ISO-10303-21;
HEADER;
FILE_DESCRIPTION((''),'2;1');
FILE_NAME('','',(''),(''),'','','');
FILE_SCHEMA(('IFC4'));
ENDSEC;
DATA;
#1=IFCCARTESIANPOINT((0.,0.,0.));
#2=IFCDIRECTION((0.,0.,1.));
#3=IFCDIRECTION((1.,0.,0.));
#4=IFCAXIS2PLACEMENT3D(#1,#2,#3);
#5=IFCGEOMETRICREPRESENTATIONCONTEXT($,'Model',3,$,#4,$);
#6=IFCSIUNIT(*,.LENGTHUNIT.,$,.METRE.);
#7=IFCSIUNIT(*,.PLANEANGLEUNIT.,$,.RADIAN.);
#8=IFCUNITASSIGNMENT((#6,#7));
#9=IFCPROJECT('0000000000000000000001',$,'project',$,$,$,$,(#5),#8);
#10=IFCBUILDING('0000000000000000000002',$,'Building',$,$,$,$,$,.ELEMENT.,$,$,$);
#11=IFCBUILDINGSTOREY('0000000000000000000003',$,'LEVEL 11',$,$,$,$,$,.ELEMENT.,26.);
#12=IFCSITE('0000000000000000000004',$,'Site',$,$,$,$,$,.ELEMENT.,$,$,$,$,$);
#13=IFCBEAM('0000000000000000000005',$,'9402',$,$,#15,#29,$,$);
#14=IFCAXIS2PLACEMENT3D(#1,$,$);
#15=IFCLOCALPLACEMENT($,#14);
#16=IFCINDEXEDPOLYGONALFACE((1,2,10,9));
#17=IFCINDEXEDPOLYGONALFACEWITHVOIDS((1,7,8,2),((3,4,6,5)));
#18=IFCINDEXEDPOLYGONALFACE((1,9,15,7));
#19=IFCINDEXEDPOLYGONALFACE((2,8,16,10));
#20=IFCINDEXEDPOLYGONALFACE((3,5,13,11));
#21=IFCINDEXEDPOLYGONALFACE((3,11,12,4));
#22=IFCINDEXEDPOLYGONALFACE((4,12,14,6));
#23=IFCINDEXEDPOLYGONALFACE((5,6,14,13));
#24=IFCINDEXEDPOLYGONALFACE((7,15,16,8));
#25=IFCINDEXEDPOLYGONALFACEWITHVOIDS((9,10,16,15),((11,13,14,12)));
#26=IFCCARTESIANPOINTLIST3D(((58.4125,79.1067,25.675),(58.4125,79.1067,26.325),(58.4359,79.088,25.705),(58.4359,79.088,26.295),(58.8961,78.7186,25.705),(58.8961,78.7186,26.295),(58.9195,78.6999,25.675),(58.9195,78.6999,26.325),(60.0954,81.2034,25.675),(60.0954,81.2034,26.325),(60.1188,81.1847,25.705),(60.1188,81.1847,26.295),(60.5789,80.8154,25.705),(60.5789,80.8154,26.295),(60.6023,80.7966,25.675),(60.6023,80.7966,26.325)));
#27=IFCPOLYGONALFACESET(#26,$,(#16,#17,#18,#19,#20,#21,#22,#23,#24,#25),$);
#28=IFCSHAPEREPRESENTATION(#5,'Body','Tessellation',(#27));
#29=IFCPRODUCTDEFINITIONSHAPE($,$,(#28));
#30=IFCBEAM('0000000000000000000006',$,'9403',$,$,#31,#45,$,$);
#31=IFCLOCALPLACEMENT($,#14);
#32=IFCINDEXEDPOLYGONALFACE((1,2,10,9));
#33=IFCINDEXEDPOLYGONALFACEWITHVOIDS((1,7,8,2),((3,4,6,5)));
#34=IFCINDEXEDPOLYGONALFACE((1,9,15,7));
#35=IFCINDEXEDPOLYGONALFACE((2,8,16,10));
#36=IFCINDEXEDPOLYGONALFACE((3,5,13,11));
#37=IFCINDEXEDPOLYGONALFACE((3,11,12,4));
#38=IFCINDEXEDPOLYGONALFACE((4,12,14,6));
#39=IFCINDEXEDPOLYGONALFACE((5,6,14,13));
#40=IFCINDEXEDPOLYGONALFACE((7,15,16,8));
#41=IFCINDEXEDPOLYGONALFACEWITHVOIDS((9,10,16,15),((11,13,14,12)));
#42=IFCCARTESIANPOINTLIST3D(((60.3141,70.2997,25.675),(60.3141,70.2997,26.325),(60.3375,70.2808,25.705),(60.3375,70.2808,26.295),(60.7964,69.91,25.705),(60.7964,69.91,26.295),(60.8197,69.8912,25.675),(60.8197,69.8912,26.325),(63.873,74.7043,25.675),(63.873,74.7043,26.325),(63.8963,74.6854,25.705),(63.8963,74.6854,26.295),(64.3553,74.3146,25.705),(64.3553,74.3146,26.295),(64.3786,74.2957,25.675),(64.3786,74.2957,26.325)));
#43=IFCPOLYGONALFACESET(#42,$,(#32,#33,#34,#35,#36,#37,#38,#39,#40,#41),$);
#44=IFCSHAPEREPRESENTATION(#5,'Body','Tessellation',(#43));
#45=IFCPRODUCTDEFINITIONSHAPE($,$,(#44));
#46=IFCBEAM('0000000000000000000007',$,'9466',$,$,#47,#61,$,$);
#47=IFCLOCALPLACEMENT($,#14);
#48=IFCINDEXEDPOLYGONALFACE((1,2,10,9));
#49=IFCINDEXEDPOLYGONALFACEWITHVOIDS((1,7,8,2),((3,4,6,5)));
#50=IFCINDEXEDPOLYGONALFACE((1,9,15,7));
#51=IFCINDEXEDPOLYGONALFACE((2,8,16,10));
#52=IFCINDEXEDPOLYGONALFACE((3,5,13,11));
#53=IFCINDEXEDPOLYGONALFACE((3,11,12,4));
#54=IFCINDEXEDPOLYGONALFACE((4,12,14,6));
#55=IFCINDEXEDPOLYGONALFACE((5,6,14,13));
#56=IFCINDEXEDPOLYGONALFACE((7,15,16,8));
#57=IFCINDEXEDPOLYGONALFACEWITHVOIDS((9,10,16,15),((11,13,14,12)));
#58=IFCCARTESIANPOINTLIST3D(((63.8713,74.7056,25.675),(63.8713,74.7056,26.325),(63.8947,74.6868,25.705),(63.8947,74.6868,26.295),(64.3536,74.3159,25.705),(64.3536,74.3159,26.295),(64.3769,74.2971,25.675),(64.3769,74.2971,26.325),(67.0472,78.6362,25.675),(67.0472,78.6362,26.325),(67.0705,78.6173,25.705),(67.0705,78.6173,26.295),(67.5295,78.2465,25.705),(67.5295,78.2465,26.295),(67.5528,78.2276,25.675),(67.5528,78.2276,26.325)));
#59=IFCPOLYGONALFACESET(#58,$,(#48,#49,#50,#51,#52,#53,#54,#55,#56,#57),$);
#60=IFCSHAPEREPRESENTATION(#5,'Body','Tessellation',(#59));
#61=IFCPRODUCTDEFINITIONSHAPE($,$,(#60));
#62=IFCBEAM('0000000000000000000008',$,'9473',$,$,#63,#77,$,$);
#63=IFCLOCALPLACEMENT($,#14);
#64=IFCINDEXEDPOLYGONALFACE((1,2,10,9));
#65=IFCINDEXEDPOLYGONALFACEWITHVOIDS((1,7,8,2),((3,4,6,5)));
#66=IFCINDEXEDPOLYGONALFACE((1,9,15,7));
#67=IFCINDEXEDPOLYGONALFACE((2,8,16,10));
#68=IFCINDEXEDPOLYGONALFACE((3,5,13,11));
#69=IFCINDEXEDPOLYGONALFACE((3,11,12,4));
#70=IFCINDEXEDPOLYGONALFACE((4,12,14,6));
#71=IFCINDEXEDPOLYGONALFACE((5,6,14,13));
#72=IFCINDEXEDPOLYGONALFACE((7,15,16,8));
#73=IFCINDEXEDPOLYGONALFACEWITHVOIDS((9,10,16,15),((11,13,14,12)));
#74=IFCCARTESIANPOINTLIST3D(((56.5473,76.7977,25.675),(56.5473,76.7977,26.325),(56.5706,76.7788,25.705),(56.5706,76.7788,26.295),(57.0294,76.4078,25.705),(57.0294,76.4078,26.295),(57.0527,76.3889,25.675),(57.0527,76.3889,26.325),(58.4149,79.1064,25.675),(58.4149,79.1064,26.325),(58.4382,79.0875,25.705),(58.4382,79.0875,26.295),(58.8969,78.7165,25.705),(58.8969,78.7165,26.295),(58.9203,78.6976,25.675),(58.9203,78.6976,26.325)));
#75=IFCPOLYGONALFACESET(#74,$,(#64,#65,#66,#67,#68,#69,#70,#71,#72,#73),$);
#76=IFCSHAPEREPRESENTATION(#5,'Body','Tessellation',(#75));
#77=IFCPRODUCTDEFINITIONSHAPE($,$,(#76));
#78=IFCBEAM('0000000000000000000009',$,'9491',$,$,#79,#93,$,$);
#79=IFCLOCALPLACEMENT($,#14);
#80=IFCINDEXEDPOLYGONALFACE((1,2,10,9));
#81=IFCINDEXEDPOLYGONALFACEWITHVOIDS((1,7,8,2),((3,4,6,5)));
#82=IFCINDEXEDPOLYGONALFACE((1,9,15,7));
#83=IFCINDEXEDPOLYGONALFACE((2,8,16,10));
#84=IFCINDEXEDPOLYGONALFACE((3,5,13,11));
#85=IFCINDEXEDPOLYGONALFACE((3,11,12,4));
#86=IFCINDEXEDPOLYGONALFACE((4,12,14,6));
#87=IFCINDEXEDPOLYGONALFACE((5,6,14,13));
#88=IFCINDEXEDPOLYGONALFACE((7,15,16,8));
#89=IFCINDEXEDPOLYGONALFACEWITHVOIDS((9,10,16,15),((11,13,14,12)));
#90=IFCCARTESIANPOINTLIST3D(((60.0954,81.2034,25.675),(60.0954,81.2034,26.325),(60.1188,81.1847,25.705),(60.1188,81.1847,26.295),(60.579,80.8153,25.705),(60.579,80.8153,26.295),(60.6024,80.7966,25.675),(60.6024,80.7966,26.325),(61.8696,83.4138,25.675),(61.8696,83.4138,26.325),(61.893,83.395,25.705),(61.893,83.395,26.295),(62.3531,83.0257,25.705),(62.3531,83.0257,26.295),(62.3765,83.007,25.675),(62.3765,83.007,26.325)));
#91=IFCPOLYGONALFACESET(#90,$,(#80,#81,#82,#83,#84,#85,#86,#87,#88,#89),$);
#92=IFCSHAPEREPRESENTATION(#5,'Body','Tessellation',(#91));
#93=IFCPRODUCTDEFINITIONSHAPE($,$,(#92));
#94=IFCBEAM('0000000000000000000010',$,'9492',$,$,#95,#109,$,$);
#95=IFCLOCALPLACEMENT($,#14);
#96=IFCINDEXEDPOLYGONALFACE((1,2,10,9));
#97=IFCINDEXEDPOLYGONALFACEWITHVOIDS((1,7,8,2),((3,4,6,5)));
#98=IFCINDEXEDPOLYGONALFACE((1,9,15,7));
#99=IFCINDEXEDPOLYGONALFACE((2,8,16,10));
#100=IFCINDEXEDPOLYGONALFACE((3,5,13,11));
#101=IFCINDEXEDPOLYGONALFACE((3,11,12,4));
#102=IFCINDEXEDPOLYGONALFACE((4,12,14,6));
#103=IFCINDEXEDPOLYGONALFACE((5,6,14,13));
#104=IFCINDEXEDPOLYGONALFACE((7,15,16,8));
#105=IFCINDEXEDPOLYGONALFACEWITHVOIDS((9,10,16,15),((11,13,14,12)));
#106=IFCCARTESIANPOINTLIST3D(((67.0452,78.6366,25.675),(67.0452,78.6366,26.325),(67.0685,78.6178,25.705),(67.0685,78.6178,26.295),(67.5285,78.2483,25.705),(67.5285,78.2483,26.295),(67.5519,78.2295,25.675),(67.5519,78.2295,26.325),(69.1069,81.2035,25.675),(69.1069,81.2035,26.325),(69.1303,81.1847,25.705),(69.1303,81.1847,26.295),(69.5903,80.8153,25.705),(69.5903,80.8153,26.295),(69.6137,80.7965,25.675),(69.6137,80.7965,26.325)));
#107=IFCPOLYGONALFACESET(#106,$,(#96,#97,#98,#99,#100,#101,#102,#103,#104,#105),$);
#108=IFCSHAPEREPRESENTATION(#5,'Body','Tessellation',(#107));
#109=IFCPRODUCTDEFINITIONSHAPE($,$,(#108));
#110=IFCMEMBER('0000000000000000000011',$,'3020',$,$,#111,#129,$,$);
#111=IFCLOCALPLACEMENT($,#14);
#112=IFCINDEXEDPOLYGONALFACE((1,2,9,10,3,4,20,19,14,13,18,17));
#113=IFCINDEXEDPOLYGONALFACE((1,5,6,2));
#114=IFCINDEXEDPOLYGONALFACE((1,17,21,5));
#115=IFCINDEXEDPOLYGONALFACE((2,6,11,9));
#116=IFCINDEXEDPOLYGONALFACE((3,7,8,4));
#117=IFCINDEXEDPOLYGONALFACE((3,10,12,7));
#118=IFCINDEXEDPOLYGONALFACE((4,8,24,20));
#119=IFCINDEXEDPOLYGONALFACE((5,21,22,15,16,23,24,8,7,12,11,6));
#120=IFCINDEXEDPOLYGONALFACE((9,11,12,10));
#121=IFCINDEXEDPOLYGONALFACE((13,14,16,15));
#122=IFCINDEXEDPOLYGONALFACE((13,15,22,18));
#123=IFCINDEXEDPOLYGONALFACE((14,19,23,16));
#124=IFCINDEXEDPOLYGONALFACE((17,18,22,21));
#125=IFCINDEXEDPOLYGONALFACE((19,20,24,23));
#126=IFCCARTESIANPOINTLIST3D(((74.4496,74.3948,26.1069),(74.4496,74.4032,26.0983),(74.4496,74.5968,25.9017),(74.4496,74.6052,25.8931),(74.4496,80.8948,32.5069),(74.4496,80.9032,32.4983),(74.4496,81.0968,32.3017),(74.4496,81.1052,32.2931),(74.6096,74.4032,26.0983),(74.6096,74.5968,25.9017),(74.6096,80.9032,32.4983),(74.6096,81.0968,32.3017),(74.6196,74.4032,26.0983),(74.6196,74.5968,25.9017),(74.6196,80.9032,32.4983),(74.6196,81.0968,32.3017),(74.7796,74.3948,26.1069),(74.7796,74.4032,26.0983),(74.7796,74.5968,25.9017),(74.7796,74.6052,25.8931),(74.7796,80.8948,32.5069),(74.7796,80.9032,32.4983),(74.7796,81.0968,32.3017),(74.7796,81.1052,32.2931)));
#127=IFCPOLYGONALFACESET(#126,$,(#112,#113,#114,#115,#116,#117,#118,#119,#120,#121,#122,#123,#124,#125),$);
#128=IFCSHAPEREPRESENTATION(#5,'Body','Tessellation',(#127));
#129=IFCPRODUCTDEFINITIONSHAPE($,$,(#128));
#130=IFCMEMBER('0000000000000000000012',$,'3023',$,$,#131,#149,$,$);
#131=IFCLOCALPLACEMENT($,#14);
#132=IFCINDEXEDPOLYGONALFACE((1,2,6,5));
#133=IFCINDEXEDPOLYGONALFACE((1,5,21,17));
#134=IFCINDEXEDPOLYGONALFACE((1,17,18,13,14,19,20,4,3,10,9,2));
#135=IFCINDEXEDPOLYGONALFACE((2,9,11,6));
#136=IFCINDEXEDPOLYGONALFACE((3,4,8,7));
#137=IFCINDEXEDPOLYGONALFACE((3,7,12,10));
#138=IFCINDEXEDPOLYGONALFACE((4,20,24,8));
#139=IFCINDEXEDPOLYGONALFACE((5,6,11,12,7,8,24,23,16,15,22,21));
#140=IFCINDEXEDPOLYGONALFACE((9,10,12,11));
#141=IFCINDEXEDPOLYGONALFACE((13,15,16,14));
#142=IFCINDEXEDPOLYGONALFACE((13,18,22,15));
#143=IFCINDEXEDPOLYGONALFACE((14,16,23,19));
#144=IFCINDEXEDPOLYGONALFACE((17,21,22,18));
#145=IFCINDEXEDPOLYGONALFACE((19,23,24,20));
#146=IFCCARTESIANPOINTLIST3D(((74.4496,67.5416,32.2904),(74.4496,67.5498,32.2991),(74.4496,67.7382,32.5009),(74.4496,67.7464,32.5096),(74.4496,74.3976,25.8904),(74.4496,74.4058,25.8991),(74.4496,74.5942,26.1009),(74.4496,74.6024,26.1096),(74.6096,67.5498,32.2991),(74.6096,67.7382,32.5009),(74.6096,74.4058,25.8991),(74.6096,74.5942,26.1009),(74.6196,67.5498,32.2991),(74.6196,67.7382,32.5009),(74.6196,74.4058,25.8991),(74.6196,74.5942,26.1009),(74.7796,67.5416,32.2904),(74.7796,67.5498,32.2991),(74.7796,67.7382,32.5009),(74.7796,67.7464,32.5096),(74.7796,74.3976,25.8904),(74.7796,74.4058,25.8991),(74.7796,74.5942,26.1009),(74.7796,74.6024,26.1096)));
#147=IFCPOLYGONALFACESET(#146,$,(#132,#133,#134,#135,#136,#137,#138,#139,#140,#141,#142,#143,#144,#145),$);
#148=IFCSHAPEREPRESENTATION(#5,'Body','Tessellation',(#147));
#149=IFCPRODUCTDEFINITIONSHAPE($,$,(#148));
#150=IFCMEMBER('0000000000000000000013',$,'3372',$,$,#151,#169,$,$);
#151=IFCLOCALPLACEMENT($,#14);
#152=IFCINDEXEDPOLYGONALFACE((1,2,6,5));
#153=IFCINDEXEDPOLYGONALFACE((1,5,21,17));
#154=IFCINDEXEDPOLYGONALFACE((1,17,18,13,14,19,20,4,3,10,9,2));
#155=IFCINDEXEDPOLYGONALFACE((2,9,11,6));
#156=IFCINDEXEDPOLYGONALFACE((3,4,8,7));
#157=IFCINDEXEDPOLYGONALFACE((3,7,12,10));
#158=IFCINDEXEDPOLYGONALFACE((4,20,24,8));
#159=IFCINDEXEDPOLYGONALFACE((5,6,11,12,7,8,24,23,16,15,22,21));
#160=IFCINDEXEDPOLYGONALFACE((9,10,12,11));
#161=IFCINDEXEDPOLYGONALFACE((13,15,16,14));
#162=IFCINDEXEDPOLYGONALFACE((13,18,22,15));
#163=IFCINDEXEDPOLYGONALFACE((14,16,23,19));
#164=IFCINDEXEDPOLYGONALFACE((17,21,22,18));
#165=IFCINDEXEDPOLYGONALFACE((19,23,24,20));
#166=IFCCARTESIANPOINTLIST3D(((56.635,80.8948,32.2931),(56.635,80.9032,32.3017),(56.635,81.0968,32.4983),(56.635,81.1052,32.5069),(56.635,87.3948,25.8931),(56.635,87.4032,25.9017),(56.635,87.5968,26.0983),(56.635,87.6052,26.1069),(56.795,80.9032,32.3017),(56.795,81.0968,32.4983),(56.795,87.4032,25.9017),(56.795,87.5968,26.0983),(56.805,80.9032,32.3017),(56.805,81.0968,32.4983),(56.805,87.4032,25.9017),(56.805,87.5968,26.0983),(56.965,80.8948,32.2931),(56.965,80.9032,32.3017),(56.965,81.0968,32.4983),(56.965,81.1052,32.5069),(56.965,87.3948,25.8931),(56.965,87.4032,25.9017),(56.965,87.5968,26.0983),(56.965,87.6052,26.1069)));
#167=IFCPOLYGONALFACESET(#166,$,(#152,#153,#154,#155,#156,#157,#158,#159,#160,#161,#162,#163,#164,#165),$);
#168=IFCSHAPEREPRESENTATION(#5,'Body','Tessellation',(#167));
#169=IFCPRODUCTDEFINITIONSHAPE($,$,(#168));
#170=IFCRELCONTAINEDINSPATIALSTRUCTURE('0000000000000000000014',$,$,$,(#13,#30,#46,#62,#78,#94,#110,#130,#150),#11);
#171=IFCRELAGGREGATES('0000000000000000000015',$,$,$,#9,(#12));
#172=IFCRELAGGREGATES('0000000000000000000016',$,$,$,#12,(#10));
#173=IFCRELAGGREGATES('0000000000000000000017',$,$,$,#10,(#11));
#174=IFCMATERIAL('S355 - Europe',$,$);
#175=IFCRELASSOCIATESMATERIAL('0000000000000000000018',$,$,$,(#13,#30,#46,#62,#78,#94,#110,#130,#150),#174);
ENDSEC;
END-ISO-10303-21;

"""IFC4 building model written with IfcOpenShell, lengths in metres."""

from ifc_helpers import new_model, si_unit, frame, origin_with_axes, origin_2d_with_axis, place, context, project, spatial, hollow_rectangle, i_section, extrude, material, material_profile, profile_set, profile_usage, element, save


model = new_model("IFC4")

# Units and contexts
model_context = context("Model", 3, world=origin_with_axes())
ifc_project = project(units=[si_unit("LENGTHUNIT", "METRE"), si_unit("PLANEANGLEUNIT", "RADIAN")], contexts=[model_context])

# Site, building, storey
site = spatial("IfcSite", under=ifc_project, Name="Site", CompositionType="ELEMENT")
building = spatial("IfcBuilding", under=site, Name="Building", CompositionType="ELEMENT")
storey = spatial("IfcBuildingStorey", under=building, Name="LEVEL 11", CompositionType="ELEMENT", Elevation=26.0)

# Shared definitions
ifc_material = material(Name="S355 - Europe")

# Beams
ifc_material_profile_1 = material_profile(ifc_material, hollow_rectangle(XDim=0.65, YDim=0.65, WallThickness=0.03, at=origin_2d_with_axis()))
ifc_profile_set_1 = profile_set([ifc_material_profile_1])
ifc_profile_usage_1 = profile_usage(ifc_profile_set_1, cardinal=10)
beam_1_placement = place(None, frame((58.666, 78.9033, 26.0), z_axis=(0.625944, 0.779868, 0.0), x_axis=(-0.779651, 0.626214, 0.0)))
element("IfcBeam", 1, at=beam_1_placement, inside=storey, material=ifc_profile_usage_1, Name="9402", context=model_context, shape_type="SweptSolid", body=[
    extrude(hollow_rectangle(XDim=0.65, YDim=0.65, WallThickness=0.03, at=origin_2d_with_axis()), origin_with_axes(), (0.0, 0.0, 1.0), 2.6886),
])
ifc_material_profile_2 = material_profile(ifc_material, hollow_rectangle(XDim=0.65, YDim=0.65, WallThickness=0.03, at=origin_2d_with_axis()))
ifc_profile_set_2 = profile_set([ifc_material_profile_2])
ifc_profile_usage_2 = profile_usage(ifc_profile_set_2, cardinal=10)
beam_2_placement = place(None, frame((64.1258, 74.5, 26.0), z_axis=(-0.62848, -0.777826, 0.0), x_axis=(0.77854, -0.627595, 0.0)))
element("IfcBeam", 2, at=beam_2_placement, inside=storey, material=ifc_profile_usage_2, Name="9403", context=model_context, shape_type="SweptSolid", body=[
    extrude(hollow_rectangle(XDim=0.65, YDim=0.65, WallThickness=0.03, at=origin_2d_with_axis()), origin_with_axes(), (0.0, 0.0, 1.0), 5.6627),
])
ifc_material_profile_3 = material_profile(ifc_material, hollow_rectangle(XDim=0.65, YDim=0.65, WallThickness=0.03, at=origin_2d_with_axis()))
ifc_profile_set_3 = profile_set([ifc_material_profile_3])
ifc_profile_usage_3 = profile_usage(ifc_profile_set_3, cardinal=10)
beam_3_placement = place(None, frame((67.3, 78.4319, 26.0), z_axis=(-0.62848, -0.777826, 0.0), x_axis=(0.777711, -0.628621, 0.0)))
element("IfcBeam", 3, at=beam_3_placement, inside=storey, material=ifc_profile_usage_3, Name="9466", context=model_context, shape_type="SweptSolid", body=[
    extrude(hollow_rectangle(XDim=0.65, YDim=0.65, WallThickness=0.03, at=origin_2d_with_axis()), origin_with_axes(), (0.0, 0.0, 1.0), 5.0533),
])
ifc_material_profile_4 = material_profile(ifc_material, hollow_rectangle(XDim=0.65, YDim=0.65, WallThickness=0.03, at=origin_2d_with_axis()))
ifc_profile_set_4 = profile_set([ifc_material_profile_4])
ifc_profile_usage_4 = profile_usage(ifc_profile_set_4, cardinal=10)
beam_4_placement = place(None, frame((56.8, 76.5933, 26.0), z_axis=(0.62892, 0.77747, 0.0), x_axis=(-0.777826, 0.62848, 0.0)))
element("IfcBeam", 4, at=beam_4_placement, inside=storey, material=ifc_profile_usage_4, Name="9473", context=model_context, shape_type="SweptSolid", body=[
    extrude(hollow_rectangle(XDim=0.65, YDim=0.65, WallThickness=0.03, at=origin_2d_with_axis()), origin_with_axes(), (0.0, 0.0, 1.0), 2.9695),
])
ifc_material_profile_5 = material_profile(ifc_material, hollow_rectangle(XDim=0.65, YDim=0.65, WallThickness=0.03, at=origin_2d_with_axis()))
ifc_profile_set_5 = profile_set([ifc_material_profile_5])
ifc_profile_usage_5 = profile_usage(ifc_profile_set_5, cardinal=10)
beam_5_placement = place(None, frame((60.3489, 81.0, 26.0), z_axis=(0.625944, 0.779868, 0.0), x_axis=(-0.779651, 0.626214, 0.0)))
element("IfcBeam", 5, at=beam_5_placement, inside=storey, material=ifc_profile_usage_5, Name="9491", context=model_context, shape_type="SweptSolid", body=[
    extrude(hollow_rectangle(XDim=0.65, YDim=0.65, WallThickness=0.03, at=origin_2d_with_axis()), origin_with_axes(), (0.0, 0.0, 1.0), 2.8343),
])
ifc_material_profile_6 = material_profile(ifc_material, hollow_rectangle(XDim=0.65, YDim=0.65, WallThickness=0.03, at=origin_2d_with_axis()))
ifc_profile_set_6 = profile_set([ifc_material_profile_6])
ifc_profile_usage_6 = profile_usage(ifc_profile_set_6, cardinal=10)
beam_6_placement = place(None, frame((69.3603, 81.0, 26.0), z_axis=(-0.626214, -0.779651, 0.0), x_axis=(0.780006, -0.625772, 0.0)))
element("IfcBeam", 6, at=beam_6_placement, inside=storey, material=ifc_profile_usage_6, Name="9492", context=model_context, shape_type="SweptSolid", body=[
    extrude(hollow_rectangle(XDim=0.65, YDim=0.65, WallThickness=0.03, at=origin_2d_with_axis()), origin_with_axes(), (0.0, 0.0, 1.0), 3.2924),
])

# Members
ifc_material_profile_7 = material_profile(ifc_material, i_section(OverallWidth=0.33, OverallDepth=0.3, WebThickness=0.01, FlangeThickness=0.012, at=origin_2d_with_axis()))
ifc_profile_set_7 = profile_set([ifc_material_profile_7])
ifc_profile_usage_7 = profile_usage(ifc_profile_set_7, cardinal=10)
member_1_placement = place(None, frame((74.6146, 74.5, 26.0), z_axis=(0.0, 0.712567, 0.701604), x_axis=(-1.0, 0.0, 0.0)))
element("IfcMember", 7, at=member_1_placement, inside=storey, material=ifc_profile_usage_7, Name="3020", context=model_context, shape_type="SweptSolid", body=[
    extrude(i_section(OverallWidth=0.33, OverallDepth=0.3, WebThickness=0.01, FlangeThickness=0.012, at=origin_2d_with_axis()), origin_with_axes(), (0.0, 0.0, 1.0), 9.122),
])
ifc_material_profile_8 = material_profile(ifc_material, i_section(OverallWidth=0.33, OverallDepth=0.3, WebThickness=0.01, FlangeThickness=0.012, at=origin_2d_with_axis()))
ifc_profile_set_8 = profile_set([ifc_material_profile_8])
ifc_profile_usage_8 = profile_usage(ifc_profile_set_8, cardinal=10)
member_2_placement = place(None, frame((74.6146, 74.5, 26.0), z_axis=(0.0, -0.730999, 0.682379), x_axis=(1.0, 0.0, 0.0)))
element("IfcMember", 8, at=member_2_placement, inside=storey, material=ifc_profile_usage_8, Name="3023", context=model_context, shape_type="SweptSolid", body=[
    extrude(i_section(OverallWidth=0.33, OverallDepth=0.3, WebThickness=0.01, FlangeThickness=0.012, at=origin_2d_with_axis()), origin_with_axes(), (0.0, 0.0, 1.0), 9.379),
])
ifc_material_profile_9 = material_profile(ifc_material, i_section(OverallWidth=0.33, OverallDepth=0.3, WebThickness=0.01, FlangeThickness=0.012, at=origin_2d_with_axis()))
ifc_profile_set_9 = profile_set([ifc_material_profile_9])
ifc_profile_usage_9 = profile_usage(ifc_profile_set_9, cardinal=10)
member_3_placement = place(None, frame((56.8, 81.0, 32.4), z_axis=(0.0, 0.712567, -0.701604), x_axis=(-1.0, 0.0, 0.0)))
element("IfcMember", 9, at=member_3_placement, inside=storey, material=ifc_profile_usage_9, Name="3372", context=model_context, shape_type="SweptSolid", body=[
    extrude(i_section(OverallWidth=0.33, OverallDepth=0.3, WebThickness=0.01, FlangeThickness=0.012, at=origin_2d_with_axis()), origin_with_axes(), (0.0, 0.0, 1.0), 9.122),
])

save(model, "model.ifc")
